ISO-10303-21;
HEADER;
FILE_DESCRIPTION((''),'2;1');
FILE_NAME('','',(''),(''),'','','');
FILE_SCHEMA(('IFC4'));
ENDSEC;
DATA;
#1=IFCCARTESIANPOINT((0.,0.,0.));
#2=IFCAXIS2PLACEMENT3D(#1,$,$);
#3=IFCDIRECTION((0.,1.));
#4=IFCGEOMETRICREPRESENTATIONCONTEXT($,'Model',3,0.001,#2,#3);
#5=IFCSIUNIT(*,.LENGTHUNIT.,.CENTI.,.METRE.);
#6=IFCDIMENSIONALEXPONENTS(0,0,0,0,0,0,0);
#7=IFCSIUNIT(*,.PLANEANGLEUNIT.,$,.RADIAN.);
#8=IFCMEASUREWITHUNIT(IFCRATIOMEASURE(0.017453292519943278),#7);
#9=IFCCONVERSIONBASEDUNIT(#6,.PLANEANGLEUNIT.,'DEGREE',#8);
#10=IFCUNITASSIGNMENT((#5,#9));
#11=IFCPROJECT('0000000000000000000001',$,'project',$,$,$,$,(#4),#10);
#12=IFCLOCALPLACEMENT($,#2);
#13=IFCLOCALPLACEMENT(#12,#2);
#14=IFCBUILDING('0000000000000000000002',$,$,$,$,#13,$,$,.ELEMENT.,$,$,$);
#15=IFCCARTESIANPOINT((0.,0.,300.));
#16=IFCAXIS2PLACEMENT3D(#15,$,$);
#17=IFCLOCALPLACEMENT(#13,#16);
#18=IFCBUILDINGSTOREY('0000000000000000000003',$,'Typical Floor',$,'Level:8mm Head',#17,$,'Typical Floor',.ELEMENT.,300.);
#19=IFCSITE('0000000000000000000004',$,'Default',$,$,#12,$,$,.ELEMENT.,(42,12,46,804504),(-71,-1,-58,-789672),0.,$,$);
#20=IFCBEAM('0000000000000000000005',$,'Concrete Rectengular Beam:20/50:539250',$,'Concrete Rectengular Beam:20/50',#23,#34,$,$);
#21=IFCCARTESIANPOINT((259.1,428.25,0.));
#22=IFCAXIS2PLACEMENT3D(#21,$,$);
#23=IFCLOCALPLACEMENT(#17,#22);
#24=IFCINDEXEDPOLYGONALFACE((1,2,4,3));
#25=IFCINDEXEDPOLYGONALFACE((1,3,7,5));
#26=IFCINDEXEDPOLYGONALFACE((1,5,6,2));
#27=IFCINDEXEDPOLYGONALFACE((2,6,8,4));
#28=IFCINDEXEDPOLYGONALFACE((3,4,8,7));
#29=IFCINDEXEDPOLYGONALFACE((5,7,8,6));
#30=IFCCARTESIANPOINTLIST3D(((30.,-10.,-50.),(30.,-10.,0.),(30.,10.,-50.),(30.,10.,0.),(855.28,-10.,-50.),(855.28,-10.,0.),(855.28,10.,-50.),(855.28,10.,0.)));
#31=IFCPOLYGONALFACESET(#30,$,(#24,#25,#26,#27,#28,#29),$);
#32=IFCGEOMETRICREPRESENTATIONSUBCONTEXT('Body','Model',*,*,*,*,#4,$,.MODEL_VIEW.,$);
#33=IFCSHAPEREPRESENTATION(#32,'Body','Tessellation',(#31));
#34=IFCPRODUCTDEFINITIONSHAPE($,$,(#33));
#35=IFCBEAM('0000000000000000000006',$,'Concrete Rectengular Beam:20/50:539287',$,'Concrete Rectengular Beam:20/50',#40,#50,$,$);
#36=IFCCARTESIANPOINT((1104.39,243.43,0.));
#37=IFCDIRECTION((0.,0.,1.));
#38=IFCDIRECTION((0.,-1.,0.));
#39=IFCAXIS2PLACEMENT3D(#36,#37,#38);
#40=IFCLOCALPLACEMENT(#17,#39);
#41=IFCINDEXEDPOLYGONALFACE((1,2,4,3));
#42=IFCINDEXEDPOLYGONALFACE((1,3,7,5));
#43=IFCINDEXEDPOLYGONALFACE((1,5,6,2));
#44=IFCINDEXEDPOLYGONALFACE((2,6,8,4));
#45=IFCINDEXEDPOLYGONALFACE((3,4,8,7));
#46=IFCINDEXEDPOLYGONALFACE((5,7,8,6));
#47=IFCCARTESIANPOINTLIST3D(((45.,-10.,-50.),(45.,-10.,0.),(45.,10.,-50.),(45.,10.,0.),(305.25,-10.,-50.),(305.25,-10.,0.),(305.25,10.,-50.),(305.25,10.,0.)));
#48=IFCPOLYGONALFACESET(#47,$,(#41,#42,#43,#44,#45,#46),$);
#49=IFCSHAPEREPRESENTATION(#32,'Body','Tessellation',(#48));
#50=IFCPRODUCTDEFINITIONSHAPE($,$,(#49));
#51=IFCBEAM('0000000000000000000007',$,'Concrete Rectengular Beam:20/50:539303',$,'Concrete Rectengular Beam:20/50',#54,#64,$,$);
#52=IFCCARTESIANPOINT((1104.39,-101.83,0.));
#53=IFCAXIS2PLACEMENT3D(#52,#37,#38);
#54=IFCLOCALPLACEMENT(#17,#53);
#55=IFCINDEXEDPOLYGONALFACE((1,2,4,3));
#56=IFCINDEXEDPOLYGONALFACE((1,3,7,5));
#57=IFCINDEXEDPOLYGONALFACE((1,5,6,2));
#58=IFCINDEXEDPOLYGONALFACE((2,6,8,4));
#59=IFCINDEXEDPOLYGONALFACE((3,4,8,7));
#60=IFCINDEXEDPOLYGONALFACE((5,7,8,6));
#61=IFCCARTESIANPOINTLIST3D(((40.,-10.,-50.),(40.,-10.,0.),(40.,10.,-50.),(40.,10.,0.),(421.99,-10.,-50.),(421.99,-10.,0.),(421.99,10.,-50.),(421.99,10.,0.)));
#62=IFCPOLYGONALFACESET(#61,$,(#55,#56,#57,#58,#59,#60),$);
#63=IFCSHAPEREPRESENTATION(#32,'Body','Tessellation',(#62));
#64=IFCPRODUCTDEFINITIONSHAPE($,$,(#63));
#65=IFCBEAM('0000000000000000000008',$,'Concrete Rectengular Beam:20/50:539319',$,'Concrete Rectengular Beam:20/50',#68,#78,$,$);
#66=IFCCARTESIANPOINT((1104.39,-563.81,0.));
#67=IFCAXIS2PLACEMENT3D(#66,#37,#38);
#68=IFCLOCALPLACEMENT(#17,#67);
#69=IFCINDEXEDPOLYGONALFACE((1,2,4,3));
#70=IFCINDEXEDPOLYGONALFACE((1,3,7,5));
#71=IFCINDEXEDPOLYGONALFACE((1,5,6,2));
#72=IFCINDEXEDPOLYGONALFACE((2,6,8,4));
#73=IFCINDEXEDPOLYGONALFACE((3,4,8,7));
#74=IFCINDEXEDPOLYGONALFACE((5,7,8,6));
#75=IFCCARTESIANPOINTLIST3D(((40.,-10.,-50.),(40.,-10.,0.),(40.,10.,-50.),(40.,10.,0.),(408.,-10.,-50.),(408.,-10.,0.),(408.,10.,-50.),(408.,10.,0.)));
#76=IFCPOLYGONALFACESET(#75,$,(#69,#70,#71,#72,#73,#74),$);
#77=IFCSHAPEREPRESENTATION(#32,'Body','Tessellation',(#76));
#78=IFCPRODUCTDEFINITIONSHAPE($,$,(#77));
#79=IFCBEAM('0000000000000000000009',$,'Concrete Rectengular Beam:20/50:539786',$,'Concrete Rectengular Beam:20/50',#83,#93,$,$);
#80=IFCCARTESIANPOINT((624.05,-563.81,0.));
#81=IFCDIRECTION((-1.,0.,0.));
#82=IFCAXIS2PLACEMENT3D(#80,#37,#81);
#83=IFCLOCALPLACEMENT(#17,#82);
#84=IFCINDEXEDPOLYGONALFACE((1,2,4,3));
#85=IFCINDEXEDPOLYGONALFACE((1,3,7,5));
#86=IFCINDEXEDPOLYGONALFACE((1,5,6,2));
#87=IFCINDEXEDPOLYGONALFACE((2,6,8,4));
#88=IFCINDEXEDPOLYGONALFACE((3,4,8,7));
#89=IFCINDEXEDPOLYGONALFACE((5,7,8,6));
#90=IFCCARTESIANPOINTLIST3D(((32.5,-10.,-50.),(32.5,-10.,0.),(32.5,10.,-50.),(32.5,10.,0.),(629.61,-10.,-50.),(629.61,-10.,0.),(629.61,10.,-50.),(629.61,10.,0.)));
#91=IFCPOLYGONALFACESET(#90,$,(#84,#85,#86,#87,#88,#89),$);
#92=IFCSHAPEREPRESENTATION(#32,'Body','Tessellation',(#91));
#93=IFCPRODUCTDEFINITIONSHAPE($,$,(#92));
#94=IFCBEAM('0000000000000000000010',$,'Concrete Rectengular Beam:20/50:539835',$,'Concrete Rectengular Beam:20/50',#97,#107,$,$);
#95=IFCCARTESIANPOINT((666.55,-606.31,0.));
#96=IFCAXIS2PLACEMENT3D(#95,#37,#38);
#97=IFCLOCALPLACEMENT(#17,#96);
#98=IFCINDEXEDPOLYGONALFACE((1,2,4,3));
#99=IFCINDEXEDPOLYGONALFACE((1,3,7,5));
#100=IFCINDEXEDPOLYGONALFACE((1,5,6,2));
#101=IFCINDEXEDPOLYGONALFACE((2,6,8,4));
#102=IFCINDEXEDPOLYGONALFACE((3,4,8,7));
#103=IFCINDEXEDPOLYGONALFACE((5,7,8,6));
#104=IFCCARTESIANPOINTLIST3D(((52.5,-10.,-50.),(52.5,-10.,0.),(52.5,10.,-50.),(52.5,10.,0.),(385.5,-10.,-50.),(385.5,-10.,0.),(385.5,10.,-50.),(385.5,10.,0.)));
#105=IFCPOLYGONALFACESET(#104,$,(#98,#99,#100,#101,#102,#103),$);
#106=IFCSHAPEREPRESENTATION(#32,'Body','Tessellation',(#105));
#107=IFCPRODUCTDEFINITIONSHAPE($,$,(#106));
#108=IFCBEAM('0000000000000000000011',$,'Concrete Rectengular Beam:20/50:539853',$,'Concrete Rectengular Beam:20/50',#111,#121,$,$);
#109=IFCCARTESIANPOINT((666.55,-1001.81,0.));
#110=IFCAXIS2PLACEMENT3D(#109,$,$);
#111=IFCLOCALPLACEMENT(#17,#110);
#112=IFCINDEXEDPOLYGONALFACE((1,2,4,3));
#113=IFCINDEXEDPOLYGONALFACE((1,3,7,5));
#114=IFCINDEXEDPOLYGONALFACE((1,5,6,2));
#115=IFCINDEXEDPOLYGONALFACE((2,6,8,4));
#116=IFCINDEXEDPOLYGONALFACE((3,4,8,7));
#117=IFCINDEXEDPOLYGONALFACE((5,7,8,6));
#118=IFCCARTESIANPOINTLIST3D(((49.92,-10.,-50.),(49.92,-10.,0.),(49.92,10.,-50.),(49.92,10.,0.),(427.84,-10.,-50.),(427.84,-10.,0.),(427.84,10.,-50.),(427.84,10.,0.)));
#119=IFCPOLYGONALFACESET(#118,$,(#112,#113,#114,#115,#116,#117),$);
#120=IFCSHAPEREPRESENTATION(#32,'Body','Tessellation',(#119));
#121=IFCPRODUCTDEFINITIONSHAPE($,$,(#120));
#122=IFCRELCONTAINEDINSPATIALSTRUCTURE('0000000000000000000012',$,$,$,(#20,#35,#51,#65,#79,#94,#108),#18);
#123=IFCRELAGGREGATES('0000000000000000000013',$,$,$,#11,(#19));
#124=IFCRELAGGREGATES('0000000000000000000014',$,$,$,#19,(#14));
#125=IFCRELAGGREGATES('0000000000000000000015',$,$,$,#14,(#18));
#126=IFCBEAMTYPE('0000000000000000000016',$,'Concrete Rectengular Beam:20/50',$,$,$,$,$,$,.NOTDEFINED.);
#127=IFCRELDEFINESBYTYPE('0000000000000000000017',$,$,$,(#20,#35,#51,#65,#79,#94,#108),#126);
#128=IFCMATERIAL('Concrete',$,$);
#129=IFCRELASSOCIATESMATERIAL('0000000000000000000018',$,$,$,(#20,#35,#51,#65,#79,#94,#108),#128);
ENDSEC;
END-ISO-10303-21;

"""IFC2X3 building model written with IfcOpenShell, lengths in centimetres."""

from ifc_helpers import new_model, entity, si_unit, converted_unit, direction, frame, frame_2d, origin, origin_2d_with_axis, place, context, subcontext, project, spatial, rectangle, extrude, material, type_object, element, save


model = new_model("IFC2X3")

# Units and contexts
model_context = context("Model", 3, precision=0.001, world=origin(), true_north=direction((0.0, 1.0)))
body_context = subcontext(model_context, "Body", "Model", "MODEL_VIEW")
ifc_project = project(units=[si_unit("LENGTHUNIT", "METRE", prefix="CENTI"), converted_unit("PLANEANGLEUNIT", "DEGREE", entity("IfcRatioMeasure", 0.017453292519943278), si_unit("PLANEANGLEUNIT", "RADIAN"), dimensions=[0, 0, 0, 0, 0, 0, 0])], contexts=[model_context])

# Site, building, storey
site_placement = place(None, origin())
site = spatial("IfcSite", under=ifc_project, at=site_placement, Name="Default", CompositionType="ELEMENT", RefLatitude=(42, 12, 46, 804504), RefLongitude=(-71, -1, -58, -789672), RefElevation=0.0)
building_placement = place(site_placement, origin())
building = spatial("IfcBuilding", under=site, at=building_placement, CompositionType="ELEMENT")
storey_placement = place(building_placement, frame((0.0, 0.0, 300.0)))
storey = spatial("IfcBuildingStorey", under=building, at=storey_placement, Name="Typical Floor", ObjectType="Level:8mm Head", LongName="Typical Floor", CompositionType="ELEMENT", Elevation=300.0)

# Beams
ifc_material = material(Name="Concrete")
beam_type = type_object("IfcBeamType", Name="Concrete Rectengular Beam:20/50", PredefinedType="NOTDEFINED")
beam_1_placement = place(storey_placement, frame((259.1, 428.25, 0.0)))
element("IfcBeam", 1, at=beam_1_placement, inside=storey, type_object=beam_type, material=ifc_material, Name="Concrete Rectengular Beam:20/50:539250", ObjectType="Concrete Rectengular Beam:20/50", context=body_context, shape_type="SweptSolid", body=[
    extrude(rectangle(XDim=50.0, YDim=20.0, at=frame_2d((0.0, 0.0), x_axis=(1.0, 0.0))), frame((30.0, 0.0, -25.0), z_axis=(1.0, 0.0, 0.0), x_axis=(0.0, 0.0, -1.0)), (0.0, 0.0, 1.0), 825.28),
])
beam_2_placement = place(storey_placement, frame((1104.39, 243.43, 0.0), z_axis=(0.0, 0.0, 1.0), x_axis=(0.0, -1.0, 0.0)))
element("IfcBeam", 2, at=beam_2_placement, inside=storey, type_object=beam_type, material=ifc_material, Name="Concrete Rectengular Beam:20/50:539287", ObjectType="Concrete Rectengular Beam:20/50", context=body_context, shape_type="SweptSolid", body=[
    extrude(rectangle(XDim=50.0, YDim=20.0, at=frame_2d((0.0, 0.0), x_axis=(1.0, 0.0))), frame((45.0, 0.0, -25.0), z_axis=(1.0, 0.0, 0.0), x_axis=(0.0, 0.0, -1.0)), (0.0, 0.0, 1.0), 260.25),
])
beam_3_placement = place(storey_placement, frame((1104.39, -101.83, 0.0), z_axis=(0.0, 0.0, 1.0), x_axis=(0.0, -1.0, 0.0)))
element("IfcBeam", 3, at=beam_3_placement, inside=storey, type_object=beam_type, material=ifc_material, Name="Concrete Rectengular Beam:20/50:539303", ObjectType="Concrete Rectengular Beam:20/50", context=body_context, shape_type="SweptSolid", body=[
    extrude(rectangle(XDim=50.0, YDim=20.0, at=origin_2d_with_axis()), frame((40.0, 0.0, -25.0), z_axis=(1.0, 0.0, 0.0), x_axis=(0.0, 0.0, -1.0)), (0.0, 0.0, 1.0), 381.99),
])
beam_4_placement = place(storey_placement, frame((1104.39, -563.81, 0.0), z_axis=(0.0, 0.0, 1.0), x_axis=(0.0, -1.0, 0.0)))
element("IfcBeam", 4, at=beam_4_placement, inside=storey, type_object=beam_type, material=ifc_material, Name="Concrete Rectengular Beam:20/50:539319", ObjectType="Concrete Rectengular Beam:20/50", context=body_context, shape_type="SweptSolid", body=[
    extrude(rectangle(XDim=50.0, YDim=20.0, at=frame_2d((0.0, 0.0), x_axis=(1.0, 0.0))), frame((40.0, 0.0, -25.0), z_axis=(1.0, 0.0, 0.0), x_axis=(0.0, 0.0, -1.0)), (0.0, 0.0, 1.0), 368.0),
])
beam_5_placement = place(storey_placement, frame((624.05, -563.81, 0.0), z_axis=(0.0, 0.0, 1.0), x_axis=(-1.0, 0.0, 0.0)))
element("IfcBeam", 5, at=beam_5_placement, inside=storey, type_object=beam_type, material=ifc_material, Name="Concrete Rectengular Beam:20/50:539786", ObjectType="Concrete Rectengular Beam:20/50", context=body_context, shape_type="SweptSolid", body=[
    extrude(rectangle(XDim=50.0, YDim=20.0, at=frame_2d((0.0, 0.0), x_axis=(1.0, 0.0))), frame((32.5, 0.0, -25.0), z_axis=(1.0, 0.0, 0.0), x_axis=(0.0, 0.0, -1.0)), (0.0, 0.0, 1.0), 597.11),
])
beam_6_placement = place(storey_placement, frame((666.55, -606.31, 0.0), z_axis=(0.0, 0.0, 1.0), x_axis=(0.0, -1.0, 0.0)))
element("IfcBeam", 6, at=beam_6_placement, inside=storey, type_object=beam_type, material=ifc_material, Name="Concrete Rectengular Beam:20/50:539835", ObjectType="Concrete Rectengular Beam:20/50", context=body_context, shape_type="SweptSolid", body=[
    extrude(rectangle(XDim=50.0, YDim=20.0, at=frame_2d((0.0, 0.0), x_axis=(1.0, 0.0))), frame((52.5, 0.0, -25.0), z_axis=(1.0, 0.0, 0.0), x_axis=(0.0, 0.0, -1.0)), (0.0, 0.0, 1.0), 333.0),
])
beam_7_placement = place(storey_placement, frame((666.55, -1001.81, 0.0)))
element("IfcBeam", 7, at=beam_7_placement, inside=storey, type_object=beam_type, material=ifc_material, Name="Concrete Rectengular Beam:20/50:539853", ObjectType="Concrete Rectengular Beam:20/50", context=body_context, shape_type="SweptSolid", body=[
    extrude(rectangle(XDim=50.0, YDim=20.0, at=frame_2d((0.0, 0.0), x_axis=(1.0, 0.0))), frame((49.92, 0.0, -25.0), z_axis=(1.0, 0.0, 0.0), x_axis=(0.0, 0.0, -1.0)), (0.0, 0.0, 1.0), 377.91),
])

save(model, "model.ifc")
